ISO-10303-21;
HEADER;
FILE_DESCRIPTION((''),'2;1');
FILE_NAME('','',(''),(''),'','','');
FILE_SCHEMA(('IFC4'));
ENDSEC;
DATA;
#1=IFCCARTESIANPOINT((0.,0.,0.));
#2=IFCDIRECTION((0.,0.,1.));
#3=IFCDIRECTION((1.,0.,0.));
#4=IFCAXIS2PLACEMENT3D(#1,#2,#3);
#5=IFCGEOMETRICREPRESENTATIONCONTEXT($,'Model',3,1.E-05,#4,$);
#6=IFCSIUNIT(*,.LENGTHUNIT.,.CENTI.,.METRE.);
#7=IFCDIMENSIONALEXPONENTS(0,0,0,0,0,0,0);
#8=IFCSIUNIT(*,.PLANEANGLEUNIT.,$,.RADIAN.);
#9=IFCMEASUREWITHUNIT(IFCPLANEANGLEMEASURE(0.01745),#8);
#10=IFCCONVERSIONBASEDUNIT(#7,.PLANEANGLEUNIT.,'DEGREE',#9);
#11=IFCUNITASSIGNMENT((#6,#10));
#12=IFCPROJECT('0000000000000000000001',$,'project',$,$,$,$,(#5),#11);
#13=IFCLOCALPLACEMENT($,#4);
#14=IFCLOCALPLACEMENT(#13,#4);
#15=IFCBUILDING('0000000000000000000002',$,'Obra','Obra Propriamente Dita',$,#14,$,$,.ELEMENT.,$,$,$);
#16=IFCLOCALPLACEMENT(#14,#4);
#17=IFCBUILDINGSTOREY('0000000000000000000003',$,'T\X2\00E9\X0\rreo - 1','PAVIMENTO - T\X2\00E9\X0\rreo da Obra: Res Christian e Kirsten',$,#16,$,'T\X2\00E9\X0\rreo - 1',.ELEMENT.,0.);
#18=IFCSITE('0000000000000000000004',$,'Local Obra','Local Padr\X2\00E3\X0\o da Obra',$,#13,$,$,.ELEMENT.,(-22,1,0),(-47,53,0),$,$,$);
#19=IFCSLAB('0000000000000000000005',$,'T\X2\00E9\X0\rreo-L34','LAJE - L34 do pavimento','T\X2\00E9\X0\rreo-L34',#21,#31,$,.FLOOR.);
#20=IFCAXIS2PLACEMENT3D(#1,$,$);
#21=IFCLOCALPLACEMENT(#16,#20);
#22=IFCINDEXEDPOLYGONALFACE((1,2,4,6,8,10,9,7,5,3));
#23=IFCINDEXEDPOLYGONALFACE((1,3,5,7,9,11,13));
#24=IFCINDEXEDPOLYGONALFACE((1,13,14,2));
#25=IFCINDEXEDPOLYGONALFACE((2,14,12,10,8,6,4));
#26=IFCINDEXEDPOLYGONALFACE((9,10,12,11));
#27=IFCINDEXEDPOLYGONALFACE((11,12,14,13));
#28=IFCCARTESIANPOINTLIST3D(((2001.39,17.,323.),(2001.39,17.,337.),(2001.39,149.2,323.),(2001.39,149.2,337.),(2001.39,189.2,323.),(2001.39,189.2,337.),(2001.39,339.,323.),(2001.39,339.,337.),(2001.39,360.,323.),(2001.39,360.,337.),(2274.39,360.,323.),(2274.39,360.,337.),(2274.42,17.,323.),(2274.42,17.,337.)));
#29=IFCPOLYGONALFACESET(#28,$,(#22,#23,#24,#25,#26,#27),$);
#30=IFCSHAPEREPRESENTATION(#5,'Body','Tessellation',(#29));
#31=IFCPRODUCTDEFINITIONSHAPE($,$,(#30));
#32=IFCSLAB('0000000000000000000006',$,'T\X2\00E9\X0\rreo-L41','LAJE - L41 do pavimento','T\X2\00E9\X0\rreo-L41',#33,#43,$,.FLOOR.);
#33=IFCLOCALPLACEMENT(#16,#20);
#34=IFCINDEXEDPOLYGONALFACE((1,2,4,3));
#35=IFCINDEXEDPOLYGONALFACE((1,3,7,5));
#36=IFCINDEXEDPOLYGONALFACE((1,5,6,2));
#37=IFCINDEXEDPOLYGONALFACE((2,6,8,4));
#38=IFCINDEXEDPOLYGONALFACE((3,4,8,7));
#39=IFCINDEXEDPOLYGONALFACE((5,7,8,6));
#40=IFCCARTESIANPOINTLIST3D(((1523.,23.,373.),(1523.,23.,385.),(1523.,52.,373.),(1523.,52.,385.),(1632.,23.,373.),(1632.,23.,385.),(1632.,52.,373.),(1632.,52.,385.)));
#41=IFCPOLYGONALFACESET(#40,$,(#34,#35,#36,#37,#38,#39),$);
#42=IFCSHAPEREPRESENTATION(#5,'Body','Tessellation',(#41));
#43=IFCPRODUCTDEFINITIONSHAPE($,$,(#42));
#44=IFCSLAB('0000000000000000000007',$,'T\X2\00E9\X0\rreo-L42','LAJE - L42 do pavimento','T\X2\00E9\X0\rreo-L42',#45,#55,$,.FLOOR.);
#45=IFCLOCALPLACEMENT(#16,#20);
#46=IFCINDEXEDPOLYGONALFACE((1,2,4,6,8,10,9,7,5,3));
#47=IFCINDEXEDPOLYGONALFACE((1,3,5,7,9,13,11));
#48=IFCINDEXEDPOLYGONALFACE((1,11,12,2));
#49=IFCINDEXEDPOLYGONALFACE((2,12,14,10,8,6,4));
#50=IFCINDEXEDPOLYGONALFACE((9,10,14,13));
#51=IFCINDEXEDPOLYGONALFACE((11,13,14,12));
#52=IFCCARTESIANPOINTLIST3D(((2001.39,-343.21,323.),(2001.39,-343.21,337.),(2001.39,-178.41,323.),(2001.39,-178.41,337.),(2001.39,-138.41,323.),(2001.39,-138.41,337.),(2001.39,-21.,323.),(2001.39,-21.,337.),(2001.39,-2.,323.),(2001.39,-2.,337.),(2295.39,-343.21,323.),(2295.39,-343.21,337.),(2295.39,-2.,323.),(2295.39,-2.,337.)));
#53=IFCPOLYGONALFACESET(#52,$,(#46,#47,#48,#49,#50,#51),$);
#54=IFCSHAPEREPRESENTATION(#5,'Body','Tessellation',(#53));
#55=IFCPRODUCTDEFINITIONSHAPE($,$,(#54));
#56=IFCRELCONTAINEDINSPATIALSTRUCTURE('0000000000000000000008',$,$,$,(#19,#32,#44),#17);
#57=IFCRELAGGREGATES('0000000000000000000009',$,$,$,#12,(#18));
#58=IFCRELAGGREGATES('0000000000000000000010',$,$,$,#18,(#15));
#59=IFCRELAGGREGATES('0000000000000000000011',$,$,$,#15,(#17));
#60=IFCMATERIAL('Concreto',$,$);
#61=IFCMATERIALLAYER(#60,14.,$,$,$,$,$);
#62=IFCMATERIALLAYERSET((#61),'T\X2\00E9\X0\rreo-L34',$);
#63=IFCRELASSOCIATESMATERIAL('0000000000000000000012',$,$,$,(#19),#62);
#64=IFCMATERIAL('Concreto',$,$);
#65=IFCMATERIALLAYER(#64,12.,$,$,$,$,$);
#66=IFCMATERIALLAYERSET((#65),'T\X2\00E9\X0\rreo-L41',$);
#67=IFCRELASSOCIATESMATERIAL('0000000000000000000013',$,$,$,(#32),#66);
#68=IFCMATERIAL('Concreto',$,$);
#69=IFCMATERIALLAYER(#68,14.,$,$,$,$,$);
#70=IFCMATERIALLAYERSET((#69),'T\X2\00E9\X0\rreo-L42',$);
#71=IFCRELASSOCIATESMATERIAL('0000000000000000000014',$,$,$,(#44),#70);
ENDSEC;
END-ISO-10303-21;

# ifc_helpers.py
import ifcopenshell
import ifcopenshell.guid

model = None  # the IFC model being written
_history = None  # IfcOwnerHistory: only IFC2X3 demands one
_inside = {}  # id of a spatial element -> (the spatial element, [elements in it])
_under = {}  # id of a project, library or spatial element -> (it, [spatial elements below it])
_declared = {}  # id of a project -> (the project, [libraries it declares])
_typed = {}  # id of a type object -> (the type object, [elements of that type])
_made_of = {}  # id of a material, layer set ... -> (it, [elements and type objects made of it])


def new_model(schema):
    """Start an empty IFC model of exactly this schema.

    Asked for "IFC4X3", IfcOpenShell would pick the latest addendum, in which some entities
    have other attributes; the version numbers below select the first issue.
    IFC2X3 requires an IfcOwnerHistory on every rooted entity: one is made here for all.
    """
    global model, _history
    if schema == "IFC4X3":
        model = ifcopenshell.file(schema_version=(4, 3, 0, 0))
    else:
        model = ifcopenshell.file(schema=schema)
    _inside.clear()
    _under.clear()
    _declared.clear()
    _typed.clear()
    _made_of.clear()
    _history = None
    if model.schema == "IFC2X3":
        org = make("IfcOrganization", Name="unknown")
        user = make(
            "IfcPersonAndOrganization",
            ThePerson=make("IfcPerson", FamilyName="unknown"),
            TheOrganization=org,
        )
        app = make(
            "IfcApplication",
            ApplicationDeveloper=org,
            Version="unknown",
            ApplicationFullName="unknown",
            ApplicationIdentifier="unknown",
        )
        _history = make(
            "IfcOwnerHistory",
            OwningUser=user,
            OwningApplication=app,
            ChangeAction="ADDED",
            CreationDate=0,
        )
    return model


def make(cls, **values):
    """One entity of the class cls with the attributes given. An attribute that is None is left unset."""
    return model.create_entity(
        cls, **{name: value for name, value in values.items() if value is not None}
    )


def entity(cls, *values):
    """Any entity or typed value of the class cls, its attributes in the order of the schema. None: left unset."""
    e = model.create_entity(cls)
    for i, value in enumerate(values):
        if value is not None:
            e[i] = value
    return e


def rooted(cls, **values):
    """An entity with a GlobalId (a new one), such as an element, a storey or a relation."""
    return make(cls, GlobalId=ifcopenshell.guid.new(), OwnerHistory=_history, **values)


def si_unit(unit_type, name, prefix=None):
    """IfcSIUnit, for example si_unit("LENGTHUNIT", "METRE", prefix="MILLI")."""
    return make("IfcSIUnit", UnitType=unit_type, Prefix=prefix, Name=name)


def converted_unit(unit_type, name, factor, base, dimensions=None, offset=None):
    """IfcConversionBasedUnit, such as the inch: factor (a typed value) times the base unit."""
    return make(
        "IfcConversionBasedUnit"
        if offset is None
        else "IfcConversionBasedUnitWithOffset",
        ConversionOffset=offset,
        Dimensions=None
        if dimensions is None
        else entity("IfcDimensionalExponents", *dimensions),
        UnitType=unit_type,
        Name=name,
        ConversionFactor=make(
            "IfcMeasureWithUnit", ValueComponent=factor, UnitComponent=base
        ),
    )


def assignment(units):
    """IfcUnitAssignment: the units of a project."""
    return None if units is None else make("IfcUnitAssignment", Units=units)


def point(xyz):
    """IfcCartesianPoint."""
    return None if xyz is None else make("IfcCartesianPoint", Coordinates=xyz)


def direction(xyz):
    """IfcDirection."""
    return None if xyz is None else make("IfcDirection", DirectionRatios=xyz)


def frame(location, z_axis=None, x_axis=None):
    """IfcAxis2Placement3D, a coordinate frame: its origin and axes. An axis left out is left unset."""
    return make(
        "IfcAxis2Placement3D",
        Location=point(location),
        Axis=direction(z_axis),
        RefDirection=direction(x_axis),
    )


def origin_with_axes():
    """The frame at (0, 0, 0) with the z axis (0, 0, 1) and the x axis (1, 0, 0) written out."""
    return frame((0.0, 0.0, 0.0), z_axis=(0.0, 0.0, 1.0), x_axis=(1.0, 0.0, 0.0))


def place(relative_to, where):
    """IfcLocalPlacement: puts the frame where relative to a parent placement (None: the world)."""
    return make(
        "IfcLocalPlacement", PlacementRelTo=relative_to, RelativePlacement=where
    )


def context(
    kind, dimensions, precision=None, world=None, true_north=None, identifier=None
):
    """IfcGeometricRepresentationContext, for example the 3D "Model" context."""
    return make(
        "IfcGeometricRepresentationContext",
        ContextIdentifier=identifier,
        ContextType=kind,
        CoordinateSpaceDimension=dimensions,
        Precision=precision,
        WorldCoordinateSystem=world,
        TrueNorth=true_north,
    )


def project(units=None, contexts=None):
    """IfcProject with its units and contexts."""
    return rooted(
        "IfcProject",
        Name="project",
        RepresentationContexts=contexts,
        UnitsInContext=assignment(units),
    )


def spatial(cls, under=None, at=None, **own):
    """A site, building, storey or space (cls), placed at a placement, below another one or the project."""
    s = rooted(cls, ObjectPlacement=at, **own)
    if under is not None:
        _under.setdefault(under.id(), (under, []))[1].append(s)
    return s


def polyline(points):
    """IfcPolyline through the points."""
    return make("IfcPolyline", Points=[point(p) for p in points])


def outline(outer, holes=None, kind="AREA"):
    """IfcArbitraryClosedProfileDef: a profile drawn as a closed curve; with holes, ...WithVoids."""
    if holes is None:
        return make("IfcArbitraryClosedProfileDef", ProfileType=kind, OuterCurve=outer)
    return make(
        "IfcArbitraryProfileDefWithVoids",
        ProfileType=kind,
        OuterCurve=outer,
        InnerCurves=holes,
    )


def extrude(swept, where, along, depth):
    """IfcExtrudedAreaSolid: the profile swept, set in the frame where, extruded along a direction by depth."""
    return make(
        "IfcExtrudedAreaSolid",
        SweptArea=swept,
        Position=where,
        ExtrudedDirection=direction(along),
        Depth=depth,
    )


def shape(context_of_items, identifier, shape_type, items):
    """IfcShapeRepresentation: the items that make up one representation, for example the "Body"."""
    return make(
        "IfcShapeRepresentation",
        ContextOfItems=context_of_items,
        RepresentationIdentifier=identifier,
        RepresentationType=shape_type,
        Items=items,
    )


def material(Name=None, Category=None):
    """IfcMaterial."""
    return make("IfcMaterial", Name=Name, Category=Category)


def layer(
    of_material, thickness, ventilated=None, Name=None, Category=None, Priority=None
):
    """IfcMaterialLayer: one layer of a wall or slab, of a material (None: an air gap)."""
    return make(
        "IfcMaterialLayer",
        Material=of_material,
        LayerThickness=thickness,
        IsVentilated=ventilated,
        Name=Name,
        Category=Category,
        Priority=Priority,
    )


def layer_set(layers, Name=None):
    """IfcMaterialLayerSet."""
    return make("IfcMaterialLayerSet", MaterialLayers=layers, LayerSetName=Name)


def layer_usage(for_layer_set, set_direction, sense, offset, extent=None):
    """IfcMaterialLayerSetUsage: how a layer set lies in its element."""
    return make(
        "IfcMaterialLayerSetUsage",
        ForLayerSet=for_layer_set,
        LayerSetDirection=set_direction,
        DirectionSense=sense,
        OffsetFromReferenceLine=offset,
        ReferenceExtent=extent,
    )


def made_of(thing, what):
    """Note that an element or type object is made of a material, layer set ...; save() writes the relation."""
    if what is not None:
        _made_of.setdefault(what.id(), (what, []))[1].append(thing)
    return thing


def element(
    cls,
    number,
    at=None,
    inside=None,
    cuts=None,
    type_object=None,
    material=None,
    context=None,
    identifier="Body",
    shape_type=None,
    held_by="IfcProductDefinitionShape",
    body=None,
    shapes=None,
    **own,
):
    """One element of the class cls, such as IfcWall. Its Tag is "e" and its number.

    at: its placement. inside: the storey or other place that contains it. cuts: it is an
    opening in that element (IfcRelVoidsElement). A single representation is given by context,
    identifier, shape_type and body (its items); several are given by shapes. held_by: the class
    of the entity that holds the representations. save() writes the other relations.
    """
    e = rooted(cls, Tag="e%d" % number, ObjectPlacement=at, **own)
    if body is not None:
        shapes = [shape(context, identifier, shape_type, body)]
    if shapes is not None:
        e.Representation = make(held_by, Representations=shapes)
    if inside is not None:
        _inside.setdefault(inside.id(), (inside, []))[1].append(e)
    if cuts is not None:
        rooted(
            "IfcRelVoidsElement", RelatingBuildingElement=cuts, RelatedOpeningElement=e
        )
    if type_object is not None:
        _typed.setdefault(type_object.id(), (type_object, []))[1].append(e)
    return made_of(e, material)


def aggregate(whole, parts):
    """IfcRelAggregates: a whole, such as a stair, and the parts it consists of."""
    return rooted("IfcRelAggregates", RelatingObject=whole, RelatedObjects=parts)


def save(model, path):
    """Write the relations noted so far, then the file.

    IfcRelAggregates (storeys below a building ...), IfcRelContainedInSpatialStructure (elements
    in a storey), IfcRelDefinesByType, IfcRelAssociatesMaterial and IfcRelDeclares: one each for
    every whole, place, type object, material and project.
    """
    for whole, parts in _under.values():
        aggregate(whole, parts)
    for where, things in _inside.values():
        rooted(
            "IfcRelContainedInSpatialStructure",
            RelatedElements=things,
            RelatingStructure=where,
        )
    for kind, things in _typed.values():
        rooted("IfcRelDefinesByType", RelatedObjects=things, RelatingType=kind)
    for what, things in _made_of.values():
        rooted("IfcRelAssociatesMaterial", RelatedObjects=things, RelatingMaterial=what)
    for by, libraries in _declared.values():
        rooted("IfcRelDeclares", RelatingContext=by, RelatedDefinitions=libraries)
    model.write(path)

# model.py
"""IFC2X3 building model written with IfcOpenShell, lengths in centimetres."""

from ifc_helpers import new_model, entity, si_unit, converted_unit, frame, origin_with_axes, place, context, project, spatial, polyline, outline, extrude, material, layer, layer_set, layer_usage, element, save


model = new_model("IFC2X3")

# Units and contexts
model_context = context("Model", 3, precision=1e-05, world=origin_with_axes())
ifc_project = project(units=[si_unit("LENGTHUNIT", "METRE", prefix="CENTI"), converted_unit("PLANEANGLEUNIT", "DEGREE", entity("IfcPlaneAngleMeasure", 0.01745), si_unit("PLANEANGLEUNIT", "RADIAN"), dimensions=[0, 0, 0, 0, 0, 0, 0])], contexts=[model_context])

# Site, building, storey
site_placement = place(None, origin_with_axes())
site = spatial("IfcSite", under=ifc_project, at=site_placement, Name="Local Obra", Description="Local Padrão da Obra", CompositionType="ELEMENT", RefLatitude=(-22, 1, 0), RefLongitude=(-47, 53, 0))
building_placement = place(site_placement, origin_with_axes())
building = spatial("IfcBuilding", under=site, at=building_placement, Name="Obra", Description="Obra Propriamente Dita", CompositionType="ELEMENT")
storey_placement = place(building_placement, origin_with_axes())
storey = spatial("IfcBuildingStorey", under=building, at=storey_placement, Name="Térreo - 1", Description="PAVIMENTO - Térreo da Obra: Res Christian e Kirsten", LongName="Térreo - 1", CompositionType="ELEMENT", Elevation=0.0)

# Slabs
ifc_material_1 = material(Name="Concreto")
ifc_layer_1 = layer(ifc_material_1, 14.0)
ifc_layer_set_1 = layer_set([ifc_layer_1], Name="Térreo-L34")
ifc_layer_usage_1 = layer_usage(ifc_layer_set_1, "AXIS3", "POSITIVE", 0.0)
slab_1_placement = place(storey_placement, frame((2274.42, 17.0, 323.0), z_axis=(0.0, 0.0, 1.0), x_axis=(1.0, 0.0, 0.0)))
element("IfcSlab", 1, at=slab_1_placement, inside=storey, material=ifc_layer_usage_1, Name="Térreo-L34", Description="LAJE - L34 do pavimento", ObjectType="Térreo-L34", PredefinedType="FLOOR", context=model_context, shape_type="SweptSolid", body=[
    extrude(outline(polyline([(-0.03, 343.0), (-273.03, 343.0), (-273.03, 322.0), (-273.03, 172.2), (-273.03, 132.2), (-273.03, 0.0), (0.0, 0.0), (-0.03, 343.0)])), origin_with_axes(), (0.0, 0.0, 1.0), 14.0),
])
ifc_material_2 = material(Name="Concreto")
ifc_layer_2 = layer(ifc_material_2, 12.0)
ifc_layer_set_2 = layer_set([ifc_layer_2], Name="Térreo-L41")
ifc_layer_usage_2 = layer_usage(ifc_layer_set_2, "AXIS3", "POSITIVE", 0.0)
slab_2_placement = place(storey_placement, frame((1632.0, 23.0, 373.0), z_axis=(0.0, 0.0, 1.0), x_axis=(1.0, 0.0, 0.0)))
element("IfcSlab", 2, at=slab_2_placement, inside=storey, material=ifc_layer_usage_2, Name="Térreo-L41", Description="LAJE - L41 do pavimento", ObjectType="Térreo-L41", PredefinedType="FLOOR", context=model_context, shape_type="SweptSolid", body=[
    extrude(outline(polyline([(0.0, 29.0), (-109.0, 29.0), (-109.0, 0.0), (0.0, 0.0), (0.0, 29.0)])), origin_with_axes(), (0.0, 0.0, 1.0), 12.0),
])
ifc_material_3 = material(Name="Concreto")
ifc_layer_3 = layer(ifc_material_3, 14.0)
ifc_layer_set_3 = layer_set([ifc_layer_3], Name="Térreo-L42")
ifc_layer_usage_3 = layer_usage(ifc_layer_set_3, "AXIS3", "POSITIVE", 0.0)
slab_3_placement = place(storey_placement, frame((2295.39, -343.21, 323.0), z_axis=(0.0, 0.0, 1.0), x_axis=(1.0, 0.0, 0.0)))
element("IfcSlab", 3, at=slab_3_placement, inside=storey, material=ifc_layer_usage_3, Name="Térreo-L42", Description="LAJE - L42 do pavimento", ObjectType="Térreo-L42", PredefinedType="FLOOR", context=model_context, shape_type="SweptSolid", body=[
    extrude(outline(polyline([(0.0, 341.21), (-294.0, 341.21), (-294.0, 322.21), (-294.0, 204.8), (-294.0, 164.8), (-294.0, 0.0), (0.0, 0.0), (0.0, 341.21)])), origin_with_axes(), (0.0, 0.0, 1.0), 14.0),
])

save(model, "model.ifc")
